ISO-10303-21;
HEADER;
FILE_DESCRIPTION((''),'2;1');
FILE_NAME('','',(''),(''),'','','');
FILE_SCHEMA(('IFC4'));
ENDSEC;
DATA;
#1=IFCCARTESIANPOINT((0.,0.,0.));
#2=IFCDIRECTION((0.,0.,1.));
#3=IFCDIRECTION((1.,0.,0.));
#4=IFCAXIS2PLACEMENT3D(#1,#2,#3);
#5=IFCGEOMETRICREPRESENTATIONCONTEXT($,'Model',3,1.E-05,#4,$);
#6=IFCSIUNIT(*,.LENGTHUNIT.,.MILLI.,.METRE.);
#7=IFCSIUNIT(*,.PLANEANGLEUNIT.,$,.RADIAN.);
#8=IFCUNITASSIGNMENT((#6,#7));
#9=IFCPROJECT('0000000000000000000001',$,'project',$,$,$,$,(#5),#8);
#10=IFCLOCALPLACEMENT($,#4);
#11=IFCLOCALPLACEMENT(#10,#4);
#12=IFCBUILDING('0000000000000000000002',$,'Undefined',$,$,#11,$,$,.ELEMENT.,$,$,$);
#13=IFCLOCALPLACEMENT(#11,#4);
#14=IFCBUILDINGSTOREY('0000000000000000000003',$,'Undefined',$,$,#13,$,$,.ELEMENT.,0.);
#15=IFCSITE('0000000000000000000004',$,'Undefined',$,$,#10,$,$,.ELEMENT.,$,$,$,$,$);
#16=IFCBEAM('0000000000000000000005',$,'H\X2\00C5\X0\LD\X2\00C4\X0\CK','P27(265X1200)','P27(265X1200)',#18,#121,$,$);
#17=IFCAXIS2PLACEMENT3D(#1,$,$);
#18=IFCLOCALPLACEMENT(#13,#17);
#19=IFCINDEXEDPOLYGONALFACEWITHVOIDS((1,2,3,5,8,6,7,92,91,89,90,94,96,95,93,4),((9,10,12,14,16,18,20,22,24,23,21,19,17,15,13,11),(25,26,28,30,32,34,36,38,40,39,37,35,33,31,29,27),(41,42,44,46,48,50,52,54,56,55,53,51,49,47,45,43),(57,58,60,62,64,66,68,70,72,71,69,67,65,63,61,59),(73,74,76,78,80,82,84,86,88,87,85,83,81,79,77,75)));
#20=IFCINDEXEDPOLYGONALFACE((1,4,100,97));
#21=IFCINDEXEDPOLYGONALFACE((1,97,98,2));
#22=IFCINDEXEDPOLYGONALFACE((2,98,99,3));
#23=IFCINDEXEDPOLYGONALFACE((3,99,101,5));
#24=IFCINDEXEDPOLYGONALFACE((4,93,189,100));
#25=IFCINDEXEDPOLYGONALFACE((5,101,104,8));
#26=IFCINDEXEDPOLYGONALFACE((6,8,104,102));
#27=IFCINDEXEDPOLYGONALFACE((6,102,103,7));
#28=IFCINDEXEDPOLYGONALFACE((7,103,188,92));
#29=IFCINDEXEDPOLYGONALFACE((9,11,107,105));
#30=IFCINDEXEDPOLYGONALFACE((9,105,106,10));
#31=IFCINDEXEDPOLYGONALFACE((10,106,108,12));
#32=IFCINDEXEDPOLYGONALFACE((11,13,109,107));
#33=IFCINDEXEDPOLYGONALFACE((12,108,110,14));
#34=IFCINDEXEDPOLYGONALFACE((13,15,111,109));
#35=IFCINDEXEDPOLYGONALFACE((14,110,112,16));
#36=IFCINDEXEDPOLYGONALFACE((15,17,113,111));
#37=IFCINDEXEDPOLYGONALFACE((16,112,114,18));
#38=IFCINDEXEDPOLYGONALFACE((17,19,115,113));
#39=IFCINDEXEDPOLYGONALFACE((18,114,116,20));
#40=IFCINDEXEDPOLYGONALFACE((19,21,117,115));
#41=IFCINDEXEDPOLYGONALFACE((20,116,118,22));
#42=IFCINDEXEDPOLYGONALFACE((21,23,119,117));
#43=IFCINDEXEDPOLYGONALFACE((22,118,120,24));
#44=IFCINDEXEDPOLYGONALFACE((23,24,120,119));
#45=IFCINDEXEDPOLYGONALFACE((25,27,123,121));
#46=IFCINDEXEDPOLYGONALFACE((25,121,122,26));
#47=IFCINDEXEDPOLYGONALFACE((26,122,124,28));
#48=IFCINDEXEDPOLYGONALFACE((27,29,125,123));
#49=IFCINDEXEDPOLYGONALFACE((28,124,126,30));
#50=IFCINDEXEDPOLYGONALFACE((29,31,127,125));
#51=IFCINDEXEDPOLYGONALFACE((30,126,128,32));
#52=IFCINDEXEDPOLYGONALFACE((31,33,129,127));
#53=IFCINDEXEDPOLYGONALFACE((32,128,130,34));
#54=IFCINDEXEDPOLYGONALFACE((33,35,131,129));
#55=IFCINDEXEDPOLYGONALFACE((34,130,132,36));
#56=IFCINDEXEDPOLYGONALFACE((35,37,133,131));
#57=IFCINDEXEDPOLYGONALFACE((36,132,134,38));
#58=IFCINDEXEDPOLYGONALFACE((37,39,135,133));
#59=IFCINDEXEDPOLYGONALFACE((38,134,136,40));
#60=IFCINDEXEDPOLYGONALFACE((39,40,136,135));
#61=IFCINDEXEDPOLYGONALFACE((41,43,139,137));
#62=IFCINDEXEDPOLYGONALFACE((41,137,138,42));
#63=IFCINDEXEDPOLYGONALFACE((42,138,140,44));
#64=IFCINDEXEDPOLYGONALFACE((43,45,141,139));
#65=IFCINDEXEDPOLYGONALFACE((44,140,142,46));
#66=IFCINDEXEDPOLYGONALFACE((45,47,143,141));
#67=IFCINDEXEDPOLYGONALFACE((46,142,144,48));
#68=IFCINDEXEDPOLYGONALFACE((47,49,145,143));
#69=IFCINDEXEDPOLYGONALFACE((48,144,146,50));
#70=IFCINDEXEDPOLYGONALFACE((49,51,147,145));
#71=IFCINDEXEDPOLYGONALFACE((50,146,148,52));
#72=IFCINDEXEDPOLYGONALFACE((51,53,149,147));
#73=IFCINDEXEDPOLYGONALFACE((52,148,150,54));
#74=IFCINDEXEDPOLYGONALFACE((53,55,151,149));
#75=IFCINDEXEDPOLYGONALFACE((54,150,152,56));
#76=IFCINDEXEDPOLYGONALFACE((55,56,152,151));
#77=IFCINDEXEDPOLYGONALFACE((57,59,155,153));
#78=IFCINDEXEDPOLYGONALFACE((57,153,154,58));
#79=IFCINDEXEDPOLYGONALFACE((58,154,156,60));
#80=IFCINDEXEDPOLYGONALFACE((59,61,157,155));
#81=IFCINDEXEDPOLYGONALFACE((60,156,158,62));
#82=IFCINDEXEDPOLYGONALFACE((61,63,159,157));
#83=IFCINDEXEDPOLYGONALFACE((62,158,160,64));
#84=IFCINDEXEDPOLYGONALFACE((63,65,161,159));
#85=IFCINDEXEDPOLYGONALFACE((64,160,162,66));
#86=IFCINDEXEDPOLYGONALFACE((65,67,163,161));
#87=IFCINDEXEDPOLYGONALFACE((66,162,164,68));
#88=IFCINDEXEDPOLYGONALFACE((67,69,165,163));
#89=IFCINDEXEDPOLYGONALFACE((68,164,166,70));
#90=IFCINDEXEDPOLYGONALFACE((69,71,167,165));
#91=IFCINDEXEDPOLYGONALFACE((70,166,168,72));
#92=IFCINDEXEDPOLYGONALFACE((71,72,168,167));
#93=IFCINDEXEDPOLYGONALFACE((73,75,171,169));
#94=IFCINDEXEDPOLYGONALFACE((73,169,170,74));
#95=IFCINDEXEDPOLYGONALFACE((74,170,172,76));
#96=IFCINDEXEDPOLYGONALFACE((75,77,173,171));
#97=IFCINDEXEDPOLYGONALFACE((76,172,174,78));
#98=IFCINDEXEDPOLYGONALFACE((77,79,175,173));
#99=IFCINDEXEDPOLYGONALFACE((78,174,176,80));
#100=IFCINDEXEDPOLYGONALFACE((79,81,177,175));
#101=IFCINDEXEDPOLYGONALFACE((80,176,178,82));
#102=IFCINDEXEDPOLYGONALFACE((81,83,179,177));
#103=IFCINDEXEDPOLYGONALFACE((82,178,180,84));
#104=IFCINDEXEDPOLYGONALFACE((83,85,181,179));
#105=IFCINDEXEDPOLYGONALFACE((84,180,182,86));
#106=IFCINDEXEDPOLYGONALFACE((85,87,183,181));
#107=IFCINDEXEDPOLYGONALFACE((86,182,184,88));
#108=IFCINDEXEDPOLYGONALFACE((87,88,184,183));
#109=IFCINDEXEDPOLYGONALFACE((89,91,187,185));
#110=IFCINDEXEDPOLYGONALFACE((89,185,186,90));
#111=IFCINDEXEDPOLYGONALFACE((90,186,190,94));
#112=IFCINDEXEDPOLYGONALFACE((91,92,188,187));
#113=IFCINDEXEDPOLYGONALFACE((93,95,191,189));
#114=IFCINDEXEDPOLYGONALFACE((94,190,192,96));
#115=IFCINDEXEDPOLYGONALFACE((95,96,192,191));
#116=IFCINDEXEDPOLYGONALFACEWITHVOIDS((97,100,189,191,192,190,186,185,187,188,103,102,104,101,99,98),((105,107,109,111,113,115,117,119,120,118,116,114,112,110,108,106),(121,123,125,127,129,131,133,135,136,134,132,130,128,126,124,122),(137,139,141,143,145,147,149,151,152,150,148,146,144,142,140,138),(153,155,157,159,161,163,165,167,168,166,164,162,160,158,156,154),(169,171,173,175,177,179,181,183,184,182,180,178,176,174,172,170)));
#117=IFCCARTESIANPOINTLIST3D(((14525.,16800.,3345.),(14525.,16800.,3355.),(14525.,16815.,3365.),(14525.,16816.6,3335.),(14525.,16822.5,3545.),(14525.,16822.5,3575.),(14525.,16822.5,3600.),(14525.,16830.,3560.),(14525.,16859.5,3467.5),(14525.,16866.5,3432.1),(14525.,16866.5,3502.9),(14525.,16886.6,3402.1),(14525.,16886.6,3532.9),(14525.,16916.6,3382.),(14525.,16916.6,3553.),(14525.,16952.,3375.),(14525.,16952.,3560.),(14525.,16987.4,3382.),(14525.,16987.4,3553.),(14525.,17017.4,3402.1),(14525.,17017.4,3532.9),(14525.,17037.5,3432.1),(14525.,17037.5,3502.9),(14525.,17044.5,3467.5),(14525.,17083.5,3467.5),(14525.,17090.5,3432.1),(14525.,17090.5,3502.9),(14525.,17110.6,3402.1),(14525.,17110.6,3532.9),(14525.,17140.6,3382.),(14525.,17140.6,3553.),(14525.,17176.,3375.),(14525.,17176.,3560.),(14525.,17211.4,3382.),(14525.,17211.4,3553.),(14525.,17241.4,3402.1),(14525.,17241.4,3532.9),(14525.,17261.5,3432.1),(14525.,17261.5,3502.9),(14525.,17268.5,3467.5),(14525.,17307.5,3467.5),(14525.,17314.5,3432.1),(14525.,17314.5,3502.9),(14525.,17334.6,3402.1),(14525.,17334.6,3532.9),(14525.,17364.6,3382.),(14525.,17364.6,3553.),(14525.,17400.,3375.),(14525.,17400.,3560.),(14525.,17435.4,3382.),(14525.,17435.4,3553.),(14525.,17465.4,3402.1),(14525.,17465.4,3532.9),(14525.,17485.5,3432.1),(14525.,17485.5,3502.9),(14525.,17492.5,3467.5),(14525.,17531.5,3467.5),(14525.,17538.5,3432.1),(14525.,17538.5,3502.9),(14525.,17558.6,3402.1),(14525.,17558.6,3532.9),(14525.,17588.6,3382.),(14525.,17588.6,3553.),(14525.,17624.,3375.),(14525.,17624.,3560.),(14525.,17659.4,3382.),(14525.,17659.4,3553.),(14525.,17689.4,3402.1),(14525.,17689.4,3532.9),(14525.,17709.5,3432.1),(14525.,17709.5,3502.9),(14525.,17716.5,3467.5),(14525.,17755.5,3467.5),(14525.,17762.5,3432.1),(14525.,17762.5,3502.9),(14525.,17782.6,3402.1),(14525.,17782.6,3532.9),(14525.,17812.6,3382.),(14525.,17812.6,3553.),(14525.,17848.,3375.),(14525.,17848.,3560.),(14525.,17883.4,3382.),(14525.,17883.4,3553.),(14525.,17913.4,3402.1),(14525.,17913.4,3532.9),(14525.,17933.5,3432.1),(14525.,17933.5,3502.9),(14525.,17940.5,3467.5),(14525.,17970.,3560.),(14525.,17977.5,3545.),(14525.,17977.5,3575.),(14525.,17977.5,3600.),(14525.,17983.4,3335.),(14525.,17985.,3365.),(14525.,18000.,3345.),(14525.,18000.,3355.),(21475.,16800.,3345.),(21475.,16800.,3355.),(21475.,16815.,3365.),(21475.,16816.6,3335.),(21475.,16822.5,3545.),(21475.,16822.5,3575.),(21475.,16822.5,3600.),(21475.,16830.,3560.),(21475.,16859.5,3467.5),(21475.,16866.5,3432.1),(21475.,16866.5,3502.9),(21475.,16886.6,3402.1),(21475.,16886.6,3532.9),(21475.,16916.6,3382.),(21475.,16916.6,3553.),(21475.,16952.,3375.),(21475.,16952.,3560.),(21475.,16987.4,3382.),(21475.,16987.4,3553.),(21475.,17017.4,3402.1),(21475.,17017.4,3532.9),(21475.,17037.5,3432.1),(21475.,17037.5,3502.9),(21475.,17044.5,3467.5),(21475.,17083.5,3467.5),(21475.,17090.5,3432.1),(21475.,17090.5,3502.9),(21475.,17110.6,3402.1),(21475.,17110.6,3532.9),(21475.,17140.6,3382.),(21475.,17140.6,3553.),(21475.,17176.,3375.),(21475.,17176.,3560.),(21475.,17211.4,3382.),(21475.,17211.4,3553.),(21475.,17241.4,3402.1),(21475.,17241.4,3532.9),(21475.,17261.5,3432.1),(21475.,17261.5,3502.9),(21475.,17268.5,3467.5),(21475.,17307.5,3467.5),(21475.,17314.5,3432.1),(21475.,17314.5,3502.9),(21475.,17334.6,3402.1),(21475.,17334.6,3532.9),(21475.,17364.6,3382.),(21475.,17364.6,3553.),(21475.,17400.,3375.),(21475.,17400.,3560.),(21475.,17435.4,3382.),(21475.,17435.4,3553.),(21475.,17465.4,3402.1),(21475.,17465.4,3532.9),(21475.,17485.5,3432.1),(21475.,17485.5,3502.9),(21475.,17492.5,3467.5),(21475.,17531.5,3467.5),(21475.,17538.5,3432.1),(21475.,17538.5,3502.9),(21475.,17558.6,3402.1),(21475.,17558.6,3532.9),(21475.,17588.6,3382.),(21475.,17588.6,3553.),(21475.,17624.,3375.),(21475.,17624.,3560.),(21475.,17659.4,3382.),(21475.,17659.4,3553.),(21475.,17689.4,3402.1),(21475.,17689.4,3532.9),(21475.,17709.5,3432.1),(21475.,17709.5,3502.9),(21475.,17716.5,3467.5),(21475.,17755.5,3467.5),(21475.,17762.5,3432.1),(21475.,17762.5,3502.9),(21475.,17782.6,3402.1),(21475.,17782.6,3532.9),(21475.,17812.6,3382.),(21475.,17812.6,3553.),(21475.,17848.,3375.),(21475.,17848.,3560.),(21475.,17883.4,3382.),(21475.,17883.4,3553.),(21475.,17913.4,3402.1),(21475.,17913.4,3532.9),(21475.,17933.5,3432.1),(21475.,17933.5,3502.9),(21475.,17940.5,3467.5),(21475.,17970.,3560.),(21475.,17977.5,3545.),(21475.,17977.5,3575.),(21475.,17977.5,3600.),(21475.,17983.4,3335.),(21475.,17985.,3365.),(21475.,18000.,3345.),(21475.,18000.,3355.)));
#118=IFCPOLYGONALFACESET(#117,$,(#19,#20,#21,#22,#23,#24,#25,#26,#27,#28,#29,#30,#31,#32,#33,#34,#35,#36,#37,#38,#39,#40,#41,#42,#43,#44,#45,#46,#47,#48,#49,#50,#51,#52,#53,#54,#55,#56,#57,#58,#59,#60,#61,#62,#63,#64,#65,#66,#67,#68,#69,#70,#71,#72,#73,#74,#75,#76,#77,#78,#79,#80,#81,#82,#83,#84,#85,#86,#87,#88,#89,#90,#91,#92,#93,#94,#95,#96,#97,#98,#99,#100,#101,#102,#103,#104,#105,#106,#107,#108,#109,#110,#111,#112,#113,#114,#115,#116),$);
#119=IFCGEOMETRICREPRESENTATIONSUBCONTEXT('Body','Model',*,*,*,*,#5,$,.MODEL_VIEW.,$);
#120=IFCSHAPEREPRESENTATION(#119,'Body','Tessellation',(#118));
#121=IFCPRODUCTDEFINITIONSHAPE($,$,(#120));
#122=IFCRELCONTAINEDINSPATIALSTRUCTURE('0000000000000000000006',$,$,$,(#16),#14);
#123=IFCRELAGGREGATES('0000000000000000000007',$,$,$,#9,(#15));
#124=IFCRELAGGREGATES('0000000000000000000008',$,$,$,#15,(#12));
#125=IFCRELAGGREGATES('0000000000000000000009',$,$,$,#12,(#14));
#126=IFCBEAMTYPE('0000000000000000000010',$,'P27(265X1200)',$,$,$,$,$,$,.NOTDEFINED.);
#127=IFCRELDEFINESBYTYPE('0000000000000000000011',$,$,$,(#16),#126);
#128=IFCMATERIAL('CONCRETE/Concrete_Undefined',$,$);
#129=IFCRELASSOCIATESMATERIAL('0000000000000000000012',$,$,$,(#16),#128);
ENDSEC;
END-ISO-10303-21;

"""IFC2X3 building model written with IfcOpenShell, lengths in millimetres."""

from ifc_helpers import new_model, si_unit, frame, origin_with_axes, place, context, subcontext, project, spatial, polyline, outline, extrude, material, type_object, element, save


model = new_model("IFC2X3")

# Units and contexts
model_context = context("Model", 3, precision=1e-05, world=origin_with_axes())
body_context = subcontext(model_context, "Body", "Model", "MODEL_VIEW")
ifc_project = project(units=[si_unit("LENGTHUNIT", "METRE", prefix="MILLI"), si_unit("PLANEANGLEUNIT", "RADIAN")], contexts=[model_context])

# Site, building, storey
site_placement = place(None, origin_with_axes())
site = spatial("IfcSite", under=ifc_project, at=site_placement, Name="Undefined", CompositionType="ELEMENT")
building_placement = place(site_placement, origin_with_axes())
building = spatial("IfcBuilding", under=site, at=building_placement, Name="Undefined", CompositionType="ELEMENT")
storey_placement = place(building_placement, origin_with_axes())
storey = spatial("IfcBuildingStorey", under=building, at=storey_placement, Name="Undefined", CompositionType="ELEMENT", Elevation=0.0)

# Beam
ifc_material_1 = material(Name="CONCRETE/Concrete_Undefined")
beam_type_1 = type_object("IfcBeamType", Name="P27(265X1200)", PredefinedType="NOTDEFINED")
beam_1_placement = place(storey_placement, frame((14525.0, 17400.0, 3467.5), z_axis=(0.0, 0.0, 1.0), x_axis=(1.0, 0.0, 0.0)))
element("IfcBeam", 1, at=beam_1_placement, inside=storey, type_object=beam_type_1, material=ifc_material_1, Name="HÅLDÄCK", Description="P27(265X1200)", ObjectType="P27(265X1200)", context=body_context, shape_type="SweptSolid", body=[
    extrude(outline(polyline([(-583.4, -132.5), (-600.0, -122.5), (-600.0, -112.5), (-585.0, -102.5), (-577.5, 77.5), (-570.0, 92.5), (-577.5, 107.5), (-577.5, 132.5), (577.5, 132.5), (577.5, 107.5), (570.0, 92.5), (577.5, 77.5), (585.0, -102.5), (600.0, -112.5), (600.0, -122.5), (583.4, -132.5), (-583.4, -132.5)]), holes=[polyline([(-513.4, 65.4), (-533.5, 35.4), (-540.5, 0.0), (-533.5, -35.4), (-513.4, -65.4), (-483.4, -85.5), (-448.0, -92.5), (-412.6, -85.5), (-382.6, -65.4), (-362.5, -35.4), (-355.5, 0.0), (-362.5, 35.4), (-382.6, 65.4), (-412.6, 85.5), (-448.0, 92.5), (-483.4, 85.5), (-513.4, 65.4)]), polyline([(-289.4, 65.4), (-309.5, 35.4), (-316.5, 0.0), (-309.5, -35.4), (-289.4, -65.4), (-259.4, -85.5), (-224.0, -92.5), (-188.6, -85.5), (-158.6, -65.4), (-138.5, -35.4), (-131.5, 0.0), (-138.5, 35.4), (-158.6, 65.4), (-188.6, 85.5), (-224.0, 92.5), (-259.4, 85.5), (-289.4, 65.4)]), polyline([(-65.4, 65.4), (-85.5, 35.4), (-92.5, 0.0), (-85.5, -35.4), (-65.4, -65.4), (-35.4, -85.5), (0.0, -92.5), (35.4, -85.5), (65.4, -65.4), (85.5, -35.4), (92.5, 0.0), (85.5, 35.4), (65.4, 65.4), (35.4, 85.5), (0.0, 92.5), (-35.4, 85.5), (-65.4, 65.4)]), polyline([(158.6, 65.4), (138.5, 35.4), (131.5, 0.0), (138.5, -35.4), (158.6, -65.4), (188.6, -85.5), (224.0, -92.5), (259.4, -85.5), (289.4, -65.4), (309.5, -35.4), (316.5, 0.0), (309.5, 35.4), (289.4, 65.4), (259.4, 85.5), (224.0, 92.5), (188.6, 85.5), (158.6, 65.4)]), polyline([(382.6, 65.4), (362.5, 35.4), (355.5, 0.0), (362.5, -35.4), (382.6, -65.4), (412.6, -85.5), (448.0, -92.5), (483.4, -85.5), (513.4, -65.4), (533.5, -35.4), (540.5, 0.0), (533.5, 35.4), (513.4, 65.4), (483.4, 85.5), (448.0, 92.5), (412.6, 85.5), (382.6, 65.4)])]), frame((6950.0, 0.0, 0.0), z_axis=(-1.0, 0.0, 0.0), x_axis=(0.0, -1.0, 0.0)), (0.0, 0.0, 1.0), 6950.0),
])

save(model, "model.ifc")
